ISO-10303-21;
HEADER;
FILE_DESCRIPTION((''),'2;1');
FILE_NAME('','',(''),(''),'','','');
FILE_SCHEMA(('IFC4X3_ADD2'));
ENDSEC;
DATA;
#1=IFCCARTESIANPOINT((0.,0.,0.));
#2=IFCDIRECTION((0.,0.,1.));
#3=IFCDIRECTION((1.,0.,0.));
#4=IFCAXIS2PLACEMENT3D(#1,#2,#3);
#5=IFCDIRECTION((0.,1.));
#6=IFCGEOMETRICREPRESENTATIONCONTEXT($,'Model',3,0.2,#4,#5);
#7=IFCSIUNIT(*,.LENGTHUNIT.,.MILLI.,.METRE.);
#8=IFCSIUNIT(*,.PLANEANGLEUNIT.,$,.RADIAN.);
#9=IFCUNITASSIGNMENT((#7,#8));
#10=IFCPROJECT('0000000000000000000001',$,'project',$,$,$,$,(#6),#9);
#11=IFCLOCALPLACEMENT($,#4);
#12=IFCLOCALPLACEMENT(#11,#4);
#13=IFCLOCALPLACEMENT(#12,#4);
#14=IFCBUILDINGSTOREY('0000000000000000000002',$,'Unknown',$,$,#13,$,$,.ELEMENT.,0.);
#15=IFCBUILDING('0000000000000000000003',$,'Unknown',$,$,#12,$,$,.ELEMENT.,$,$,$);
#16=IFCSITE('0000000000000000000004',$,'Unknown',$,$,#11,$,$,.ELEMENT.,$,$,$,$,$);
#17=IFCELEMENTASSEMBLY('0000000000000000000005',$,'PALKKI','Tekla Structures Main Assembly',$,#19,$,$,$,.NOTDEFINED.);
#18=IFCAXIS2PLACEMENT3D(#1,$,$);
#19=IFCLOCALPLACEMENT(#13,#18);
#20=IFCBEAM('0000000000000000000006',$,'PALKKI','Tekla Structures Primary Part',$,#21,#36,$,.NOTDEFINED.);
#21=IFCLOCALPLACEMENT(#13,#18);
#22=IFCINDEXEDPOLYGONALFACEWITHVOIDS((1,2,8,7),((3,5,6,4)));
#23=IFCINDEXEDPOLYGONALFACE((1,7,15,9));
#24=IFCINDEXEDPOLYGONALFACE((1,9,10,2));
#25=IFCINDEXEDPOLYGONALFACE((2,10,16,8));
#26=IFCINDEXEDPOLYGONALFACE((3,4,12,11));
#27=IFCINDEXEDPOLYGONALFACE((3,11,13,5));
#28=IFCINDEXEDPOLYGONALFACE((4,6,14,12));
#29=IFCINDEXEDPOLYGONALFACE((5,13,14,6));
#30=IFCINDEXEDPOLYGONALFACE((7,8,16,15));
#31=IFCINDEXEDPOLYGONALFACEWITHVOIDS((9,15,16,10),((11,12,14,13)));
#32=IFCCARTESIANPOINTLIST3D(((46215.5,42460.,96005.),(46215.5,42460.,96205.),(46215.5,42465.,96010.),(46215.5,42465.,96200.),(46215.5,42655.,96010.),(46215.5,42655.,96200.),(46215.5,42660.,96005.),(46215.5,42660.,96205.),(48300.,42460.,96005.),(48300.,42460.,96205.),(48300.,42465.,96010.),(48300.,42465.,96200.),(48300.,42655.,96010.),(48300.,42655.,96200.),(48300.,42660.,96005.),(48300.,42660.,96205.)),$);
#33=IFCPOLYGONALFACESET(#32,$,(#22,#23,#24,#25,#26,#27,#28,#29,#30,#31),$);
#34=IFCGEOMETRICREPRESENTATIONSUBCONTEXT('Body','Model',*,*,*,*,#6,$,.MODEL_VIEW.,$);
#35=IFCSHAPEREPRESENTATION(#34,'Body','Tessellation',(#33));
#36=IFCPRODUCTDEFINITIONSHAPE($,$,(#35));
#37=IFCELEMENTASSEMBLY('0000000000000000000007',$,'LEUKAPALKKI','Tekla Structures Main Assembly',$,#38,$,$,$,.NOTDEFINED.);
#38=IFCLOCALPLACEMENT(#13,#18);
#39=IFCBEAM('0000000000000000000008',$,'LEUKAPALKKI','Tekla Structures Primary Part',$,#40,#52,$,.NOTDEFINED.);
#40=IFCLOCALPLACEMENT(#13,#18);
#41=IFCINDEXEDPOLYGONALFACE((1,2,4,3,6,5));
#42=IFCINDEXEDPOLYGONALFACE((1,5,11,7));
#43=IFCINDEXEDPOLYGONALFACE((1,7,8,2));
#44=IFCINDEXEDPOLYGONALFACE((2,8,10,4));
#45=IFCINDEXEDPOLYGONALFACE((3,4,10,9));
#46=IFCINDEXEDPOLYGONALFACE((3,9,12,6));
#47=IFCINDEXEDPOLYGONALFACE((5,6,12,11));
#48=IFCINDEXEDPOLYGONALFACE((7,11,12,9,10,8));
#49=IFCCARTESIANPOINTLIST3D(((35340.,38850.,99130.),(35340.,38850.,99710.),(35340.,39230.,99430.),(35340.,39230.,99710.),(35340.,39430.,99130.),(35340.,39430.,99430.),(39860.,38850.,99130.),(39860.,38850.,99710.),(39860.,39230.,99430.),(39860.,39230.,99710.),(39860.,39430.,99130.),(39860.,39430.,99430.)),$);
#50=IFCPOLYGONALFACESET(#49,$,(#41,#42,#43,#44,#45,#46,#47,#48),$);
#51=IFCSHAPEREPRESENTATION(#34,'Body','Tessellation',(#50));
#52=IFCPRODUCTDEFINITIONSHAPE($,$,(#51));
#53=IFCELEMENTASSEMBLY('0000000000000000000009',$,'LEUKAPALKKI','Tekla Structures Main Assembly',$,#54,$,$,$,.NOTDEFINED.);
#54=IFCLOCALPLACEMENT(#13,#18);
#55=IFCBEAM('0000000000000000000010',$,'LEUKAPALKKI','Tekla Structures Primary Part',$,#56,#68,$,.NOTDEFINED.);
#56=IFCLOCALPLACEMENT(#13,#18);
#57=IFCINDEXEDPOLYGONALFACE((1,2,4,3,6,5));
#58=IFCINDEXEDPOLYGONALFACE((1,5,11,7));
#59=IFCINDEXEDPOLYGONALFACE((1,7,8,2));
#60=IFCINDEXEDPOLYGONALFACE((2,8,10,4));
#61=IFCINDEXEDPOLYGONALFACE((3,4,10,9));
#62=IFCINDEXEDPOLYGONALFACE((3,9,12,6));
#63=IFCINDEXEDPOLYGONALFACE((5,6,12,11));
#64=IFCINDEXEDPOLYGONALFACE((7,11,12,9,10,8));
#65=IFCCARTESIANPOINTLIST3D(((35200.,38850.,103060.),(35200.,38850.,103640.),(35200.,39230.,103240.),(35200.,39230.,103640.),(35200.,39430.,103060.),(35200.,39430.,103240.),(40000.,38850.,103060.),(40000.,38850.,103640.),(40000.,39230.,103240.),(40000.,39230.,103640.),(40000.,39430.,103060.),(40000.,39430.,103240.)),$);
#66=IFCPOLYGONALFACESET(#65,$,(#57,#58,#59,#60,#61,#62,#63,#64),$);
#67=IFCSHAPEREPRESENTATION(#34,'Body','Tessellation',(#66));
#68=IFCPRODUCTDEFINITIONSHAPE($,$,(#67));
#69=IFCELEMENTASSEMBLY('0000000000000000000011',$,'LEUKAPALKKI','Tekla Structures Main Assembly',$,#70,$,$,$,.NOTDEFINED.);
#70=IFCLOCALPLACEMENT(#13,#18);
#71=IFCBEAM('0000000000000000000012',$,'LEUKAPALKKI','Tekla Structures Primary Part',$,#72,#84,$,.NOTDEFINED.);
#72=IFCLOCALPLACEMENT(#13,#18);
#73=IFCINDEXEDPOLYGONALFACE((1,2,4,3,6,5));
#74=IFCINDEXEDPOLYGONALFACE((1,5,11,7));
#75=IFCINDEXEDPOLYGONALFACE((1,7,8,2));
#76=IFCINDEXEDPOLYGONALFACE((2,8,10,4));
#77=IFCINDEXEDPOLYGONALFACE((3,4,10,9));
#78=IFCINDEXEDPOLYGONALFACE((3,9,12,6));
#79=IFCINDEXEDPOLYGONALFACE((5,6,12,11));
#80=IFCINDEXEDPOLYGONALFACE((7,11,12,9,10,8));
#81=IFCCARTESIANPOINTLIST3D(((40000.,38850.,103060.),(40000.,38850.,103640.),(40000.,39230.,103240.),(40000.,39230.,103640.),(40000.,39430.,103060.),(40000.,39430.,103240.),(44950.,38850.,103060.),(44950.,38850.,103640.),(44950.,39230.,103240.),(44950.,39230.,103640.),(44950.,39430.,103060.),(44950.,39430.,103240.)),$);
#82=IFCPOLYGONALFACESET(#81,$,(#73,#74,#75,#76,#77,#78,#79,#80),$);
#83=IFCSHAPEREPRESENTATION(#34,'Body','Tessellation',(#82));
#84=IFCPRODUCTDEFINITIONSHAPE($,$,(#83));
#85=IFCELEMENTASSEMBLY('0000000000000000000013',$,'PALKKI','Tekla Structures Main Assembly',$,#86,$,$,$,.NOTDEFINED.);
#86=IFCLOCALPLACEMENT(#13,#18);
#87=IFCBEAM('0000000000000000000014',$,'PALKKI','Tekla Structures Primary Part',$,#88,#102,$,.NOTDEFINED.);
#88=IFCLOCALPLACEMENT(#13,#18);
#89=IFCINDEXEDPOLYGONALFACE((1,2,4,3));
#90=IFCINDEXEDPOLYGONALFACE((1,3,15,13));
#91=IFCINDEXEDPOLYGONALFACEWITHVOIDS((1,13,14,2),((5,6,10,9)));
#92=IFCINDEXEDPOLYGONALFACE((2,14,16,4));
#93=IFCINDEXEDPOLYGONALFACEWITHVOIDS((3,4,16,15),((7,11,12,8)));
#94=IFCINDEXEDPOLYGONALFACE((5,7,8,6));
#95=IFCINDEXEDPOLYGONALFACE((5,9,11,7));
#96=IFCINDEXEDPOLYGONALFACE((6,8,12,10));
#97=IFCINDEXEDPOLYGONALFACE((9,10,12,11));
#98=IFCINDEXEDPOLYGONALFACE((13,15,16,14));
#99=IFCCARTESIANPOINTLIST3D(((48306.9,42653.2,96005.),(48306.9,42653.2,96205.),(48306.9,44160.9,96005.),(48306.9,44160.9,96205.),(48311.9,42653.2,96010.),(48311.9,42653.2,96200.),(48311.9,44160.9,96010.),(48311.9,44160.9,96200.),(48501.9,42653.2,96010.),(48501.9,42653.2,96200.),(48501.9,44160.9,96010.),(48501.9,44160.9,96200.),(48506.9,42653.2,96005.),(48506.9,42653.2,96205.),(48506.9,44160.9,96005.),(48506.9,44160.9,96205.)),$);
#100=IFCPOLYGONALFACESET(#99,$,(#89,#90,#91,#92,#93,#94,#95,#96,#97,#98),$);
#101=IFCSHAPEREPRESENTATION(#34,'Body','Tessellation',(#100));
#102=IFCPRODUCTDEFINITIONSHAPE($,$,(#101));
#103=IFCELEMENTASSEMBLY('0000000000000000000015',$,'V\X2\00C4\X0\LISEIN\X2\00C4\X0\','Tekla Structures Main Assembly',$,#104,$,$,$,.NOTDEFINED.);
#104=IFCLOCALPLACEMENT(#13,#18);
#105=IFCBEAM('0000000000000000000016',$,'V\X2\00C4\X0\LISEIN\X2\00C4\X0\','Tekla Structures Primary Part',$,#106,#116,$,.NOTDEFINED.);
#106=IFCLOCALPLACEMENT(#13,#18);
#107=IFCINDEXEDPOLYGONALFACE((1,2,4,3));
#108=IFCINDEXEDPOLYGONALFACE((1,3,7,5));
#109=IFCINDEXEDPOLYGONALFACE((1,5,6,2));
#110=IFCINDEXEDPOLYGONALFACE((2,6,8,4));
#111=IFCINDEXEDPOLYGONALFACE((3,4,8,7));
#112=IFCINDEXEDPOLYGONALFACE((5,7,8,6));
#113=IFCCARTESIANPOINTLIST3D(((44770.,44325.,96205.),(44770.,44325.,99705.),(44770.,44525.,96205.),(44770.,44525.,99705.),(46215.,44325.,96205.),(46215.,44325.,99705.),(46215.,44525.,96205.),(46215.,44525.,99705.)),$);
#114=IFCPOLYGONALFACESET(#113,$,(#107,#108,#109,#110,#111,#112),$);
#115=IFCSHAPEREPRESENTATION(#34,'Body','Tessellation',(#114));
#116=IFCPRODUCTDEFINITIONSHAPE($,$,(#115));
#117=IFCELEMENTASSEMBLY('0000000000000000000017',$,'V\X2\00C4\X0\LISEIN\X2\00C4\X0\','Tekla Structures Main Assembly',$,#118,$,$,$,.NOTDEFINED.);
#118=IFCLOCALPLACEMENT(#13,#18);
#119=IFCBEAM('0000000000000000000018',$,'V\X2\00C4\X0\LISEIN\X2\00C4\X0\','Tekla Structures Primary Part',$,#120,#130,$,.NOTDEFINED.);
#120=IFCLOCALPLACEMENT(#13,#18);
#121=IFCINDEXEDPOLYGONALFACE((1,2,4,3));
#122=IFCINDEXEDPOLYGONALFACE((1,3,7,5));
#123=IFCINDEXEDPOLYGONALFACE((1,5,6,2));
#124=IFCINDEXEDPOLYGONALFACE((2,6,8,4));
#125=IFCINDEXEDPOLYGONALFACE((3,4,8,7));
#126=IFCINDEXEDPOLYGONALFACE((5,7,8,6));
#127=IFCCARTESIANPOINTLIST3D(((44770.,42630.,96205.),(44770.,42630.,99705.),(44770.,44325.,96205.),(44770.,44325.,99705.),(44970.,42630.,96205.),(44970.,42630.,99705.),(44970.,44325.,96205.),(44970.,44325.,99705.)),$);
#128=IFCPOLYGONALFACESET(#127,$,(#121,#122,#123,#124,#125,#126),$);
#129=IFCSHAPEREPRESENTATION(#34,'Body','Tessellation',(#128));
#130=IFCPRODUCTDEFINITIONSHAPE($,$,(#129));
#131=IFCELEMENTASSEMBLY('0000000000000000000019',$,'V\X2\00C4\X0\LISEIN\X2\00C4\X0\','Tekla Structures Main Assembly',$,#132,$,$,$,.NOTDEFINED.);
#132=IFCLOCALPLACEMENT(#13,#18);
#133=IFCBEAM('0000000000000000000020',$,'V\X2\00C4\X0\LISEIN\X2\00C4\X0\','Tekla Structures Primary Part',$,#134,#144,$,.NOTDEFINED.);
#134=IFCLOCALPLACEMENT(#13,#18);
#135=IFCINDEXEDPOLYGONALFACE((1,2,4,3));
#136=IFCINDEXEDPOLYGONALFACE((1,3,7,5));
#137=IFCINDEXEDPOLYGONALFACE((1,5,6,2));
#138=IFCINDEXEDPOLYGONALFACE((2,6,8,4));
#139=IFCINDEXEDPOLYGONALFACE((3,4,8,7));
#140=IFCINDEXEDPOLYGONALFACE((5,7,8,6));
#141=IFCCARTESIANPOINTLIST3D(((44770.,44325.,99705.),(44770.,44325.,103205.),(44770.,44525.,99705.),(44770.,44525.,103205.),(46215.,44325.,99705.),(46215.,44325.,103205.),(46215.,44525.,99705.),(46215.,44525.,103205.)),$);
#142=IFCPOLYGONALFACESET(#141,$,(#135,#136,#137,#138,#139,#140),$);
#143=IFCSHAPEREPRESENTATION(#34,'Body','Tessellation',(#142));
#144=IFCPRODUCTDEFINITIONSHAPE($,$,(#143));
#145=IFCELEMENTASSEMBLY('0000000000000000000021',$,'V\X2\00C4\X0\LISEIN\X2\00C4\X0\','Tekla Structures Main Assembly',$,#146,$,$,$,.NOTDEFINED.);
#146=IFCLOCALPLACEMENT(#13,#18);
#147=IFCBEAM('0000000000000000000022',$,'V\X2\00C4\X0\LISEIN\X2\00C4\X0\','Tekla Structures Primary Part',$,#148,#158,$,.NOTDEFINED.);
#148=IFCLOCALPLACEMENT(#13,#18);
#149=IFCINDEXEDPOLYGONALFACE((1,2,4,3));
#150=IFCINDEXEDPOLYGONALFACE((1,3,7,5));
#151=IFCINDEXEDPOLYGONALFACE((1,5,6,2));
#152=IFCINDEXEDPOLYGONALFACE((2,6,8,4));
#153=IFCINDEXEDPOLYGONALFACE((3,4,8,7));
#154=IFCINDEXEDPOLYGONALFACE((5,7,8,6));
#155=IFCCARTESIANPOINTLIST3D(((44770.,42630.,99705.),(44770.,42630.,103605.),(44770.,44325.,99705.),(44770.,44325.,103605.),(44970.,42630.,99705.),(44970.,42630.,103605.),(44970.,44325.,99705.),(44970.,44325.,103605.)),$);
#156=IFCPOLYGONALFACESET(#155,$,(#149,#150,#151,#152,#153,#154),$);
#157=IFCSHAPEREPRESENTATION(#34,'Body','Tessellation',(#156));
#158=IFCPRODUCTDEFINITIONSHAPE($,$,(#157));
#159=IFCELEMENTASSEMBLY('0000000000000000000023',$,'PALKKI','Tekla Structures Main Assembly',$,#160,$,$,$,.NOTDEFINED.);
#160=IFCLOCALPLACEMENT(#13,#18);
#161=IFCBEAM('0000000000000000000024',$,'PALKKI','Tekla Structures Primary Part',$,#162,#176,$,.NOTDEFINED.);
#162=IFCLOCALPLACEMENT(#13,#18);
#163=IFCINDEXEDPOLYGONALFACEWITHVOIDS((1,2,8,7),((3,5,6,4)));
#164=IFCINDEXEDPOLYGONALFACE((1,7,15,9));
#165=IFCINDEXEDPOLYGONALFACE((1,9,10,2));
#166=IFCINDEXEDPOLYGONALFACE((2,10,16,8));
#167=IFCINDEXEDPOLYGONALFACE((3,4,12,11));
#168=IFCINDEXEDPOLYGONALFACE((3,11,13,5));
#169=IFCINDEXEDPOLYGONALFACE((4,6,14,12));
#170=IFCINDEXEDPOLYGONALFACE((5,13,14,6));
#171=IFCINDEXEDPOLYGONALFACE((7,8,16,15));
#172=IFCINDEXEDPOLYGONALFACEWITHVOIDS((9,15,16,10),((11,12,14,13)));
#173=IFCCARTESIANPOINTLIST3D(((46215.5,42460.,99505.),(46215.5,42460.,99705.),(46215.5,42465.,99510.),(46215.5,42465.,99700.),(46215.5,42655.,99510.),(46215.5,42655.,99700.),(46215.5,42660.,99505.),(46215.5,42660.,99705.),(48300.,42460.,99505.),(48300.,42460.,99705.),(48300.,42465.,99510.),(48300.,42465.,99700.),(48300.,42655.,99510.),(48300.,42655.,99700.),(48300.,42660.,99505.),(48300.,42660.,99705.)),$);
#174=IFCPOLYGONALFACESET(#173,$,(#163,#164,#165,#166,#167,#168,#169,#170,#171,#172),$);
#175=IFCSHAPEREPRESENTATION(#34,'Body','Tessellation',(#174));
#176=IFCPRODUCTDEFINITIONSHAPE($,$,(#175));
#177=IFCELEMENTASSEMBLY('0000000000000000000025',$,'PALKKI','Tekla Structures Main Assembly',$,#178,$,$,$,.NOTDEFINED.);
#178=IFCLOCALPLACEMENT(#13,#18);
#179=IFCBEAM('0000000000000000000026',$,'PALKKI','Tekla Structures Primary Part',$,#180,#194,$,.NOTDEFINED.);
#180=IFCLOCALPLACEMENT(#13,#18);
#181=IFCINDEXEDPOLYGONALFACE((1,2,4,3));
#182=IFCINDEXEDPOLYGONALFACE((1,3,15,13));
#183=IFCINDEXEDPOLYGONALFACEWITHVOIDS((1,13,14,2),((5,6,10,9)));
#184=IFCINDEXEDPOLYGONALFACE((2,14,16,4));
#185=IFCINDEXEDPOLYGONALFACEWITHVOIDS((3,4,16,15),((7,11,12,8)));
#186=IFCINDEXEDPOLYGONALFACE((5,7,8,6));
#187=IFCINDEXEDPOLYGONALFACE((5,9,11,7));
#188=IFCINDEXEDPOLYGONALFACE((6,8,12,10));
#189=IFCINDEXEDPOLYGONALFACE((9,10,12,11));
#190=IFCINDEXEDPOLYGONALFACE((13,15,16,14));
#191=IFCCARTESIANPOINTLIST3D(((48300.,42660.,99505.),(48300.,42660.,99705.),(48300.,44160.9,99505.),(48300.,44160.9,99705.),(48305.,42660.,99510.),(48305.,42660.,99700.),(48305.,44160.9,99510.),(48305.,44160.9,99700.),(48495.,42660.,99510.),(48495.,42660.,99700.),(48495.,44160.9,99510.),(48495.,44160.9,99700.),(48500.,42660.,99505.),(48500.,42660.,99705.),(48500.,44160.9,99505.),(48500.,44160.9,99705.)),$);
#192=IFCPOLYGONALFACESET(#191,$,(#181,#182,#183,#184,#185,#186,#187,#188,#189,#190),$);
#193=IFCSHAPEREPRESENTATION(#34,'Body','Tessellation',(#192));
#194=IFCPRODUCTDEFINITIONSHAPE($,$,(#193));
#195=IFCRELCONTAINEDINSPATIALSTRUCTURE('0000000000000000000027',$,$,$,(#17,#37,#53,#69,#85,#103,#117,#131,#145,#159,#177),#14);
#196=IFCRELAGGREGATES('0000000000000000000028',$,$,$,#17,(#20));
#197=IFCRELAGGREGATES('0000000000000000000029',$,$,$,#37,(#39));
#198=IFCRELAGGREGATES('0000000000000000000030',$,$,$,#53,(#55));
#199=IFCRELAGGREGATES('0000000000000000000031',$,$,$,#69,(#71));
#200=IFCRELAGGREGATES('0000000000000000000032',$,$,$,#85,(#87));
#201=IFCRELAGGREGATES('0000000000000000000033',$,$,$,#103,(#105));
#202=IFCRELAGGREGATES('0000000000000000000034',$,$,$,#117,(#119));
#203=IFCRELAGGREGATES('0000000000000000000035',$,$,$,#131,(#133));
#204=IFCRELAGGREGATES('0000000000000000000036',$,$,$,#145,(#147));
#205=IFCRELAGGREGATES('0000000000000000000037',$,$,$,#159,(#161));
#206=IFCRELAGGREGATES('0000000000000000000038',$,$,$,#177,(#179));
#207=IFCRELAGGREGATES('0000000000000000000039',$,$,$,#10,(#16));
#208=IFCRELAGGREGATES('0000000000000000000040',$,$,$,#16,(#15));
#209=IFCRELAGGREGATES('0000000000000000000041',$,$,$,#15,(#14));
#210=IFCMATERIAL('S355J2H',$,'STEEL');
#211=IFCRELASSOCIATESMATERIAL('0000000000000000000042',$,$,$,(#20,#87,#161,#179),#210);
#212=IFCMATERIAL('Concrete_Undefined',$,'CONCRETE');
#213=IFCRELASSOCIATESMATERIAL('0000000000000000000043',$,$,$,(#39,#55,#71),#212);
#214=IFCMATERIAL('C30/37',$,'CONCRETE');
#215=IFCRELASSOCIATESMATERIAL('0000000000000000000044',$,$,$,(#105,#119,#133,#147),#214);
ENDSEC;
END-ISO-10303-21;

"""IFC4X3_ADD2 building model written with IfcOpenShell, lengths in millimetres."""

from ifc_helpers import new_model, si_unit, direction, frame, origin_with_axes, place, context, subcontext, project, spatial, line, indexed_curve, outline, extrude, material, element, aggregate, save


model = new_model("IFC4X3_ADD2")

# Units and contexts
model_context = context("Model", 3, precision=0.2, world=origin_with_axes(), true_north=direction((0.0, 1.0)))
body_context = subcontext(model_context, "Body", "Model", "MODEL_VIEW")
ifc_project = project(units=[si_unit("LENGTHUNIT", "METRE", prefix="MILLI"), si_unit("PLANEANGLEUNIT", "RADIAN")], contexts=[model_context])

# Site, building, storey
site_placement = place(None, origin_with_axes())
site = spatial("IfcSite", under=ifc_project, at=site_placement, Name="Unknown", CompositionType="ELEMENT")
building_placement = place(site_placement, origin_with_axes())
building = spatial("IfcBuilding", under=site, at=building_placement, Name="Unknown", CompositionType="ELEMENT")
storey_placement = place(building_placement, origin_with_axes())
storey = spatial("IfcBuildingStorey", under=building, at=storey_placement, Name="Unknown", CompositionType="ELEMENT", Elevation=0.0)

# Element assemblies, beams
assembly_1_placement = place(storey_placement, frame((46215.5, 42560.0, 96105.0), z_axis=(0.0, -1.0, 0.0), x_axis=(1.0, 0.0, 0.0)))
assembly_1 = element("IfcElementAssembly", 1, at=assembly_1_placement, inside=storey, Name="PALKKI", Description="Tekla Structures Main Assembly", PredefinedType="NOTDEFINED")
ifc_material_1 = material(Name="S355J2H", Category="STEEL")
beam_1_placement = place(assembly_1_placement, origin_with_axes())
beam_1 = element("IfcBeam", 2, at=beam_1_placement, material=ifc_material_1, Name="PALKKI", Description="Tekla Structures Primary Part", PredefinedType="NOTDEFINED", context=body_context, shape_type="SolidModel", body=[
    extrude(outline(indexed_curve([(-100.0, -100.0), (100.0, -100.0), (100.0, 100.0), (-100.0, 100.0)], segments=[line(1, 2, 3, 4, 1)]), holes=[indexed_curve([(-95.0, -95.0), (-95.0, 95.0), (95.0, 95.0), (95.0, -95.0)], segments=[line(1, 2, 3, 4, 1)])]), frame((0.0, 0.0, 0.0), z_axis=(-1.0, 0.0, 0.0), x_axis=(0.0, 0.0, 1.0)), (0.0, 0.0, -1.0), 2084.5),
])
aggregate(assembly_1, [beam_1])
assembly_2_placement = place(storey_placement, frame((39860.0, 39040.0, 99420.0), z_axis=(0.0, 1.0, 0.0), x_axis=(-1.0, 0.0, 0.0)))
assembly_2 = element("IfcElementAssembly", 3, at=assembly_2_placement, inside=storey, Name="LEUKAPALKKI", Description="Tekla Structures Main Assembly", PredefinedType="NOTDEFINED")
ifc_material_2 = material(Name="Concrete_Undefined", Category="CONCRETE")
beam_2_placement = place(assembly_2_placement, origin_with_axes())
beam_2 = element("IfcBeam", 4, at=beam_2_placement, material=ifc_material_2, Name="LEUKAPALKKI", Description="Tekla Structures Primary Part", PredefinedType="NOTDEFINED", context=body_context, shape_type="SolidModel", body=[
    extrude(outline(indexed_curve([(-190.0, -290.0), (390.0, -290.0), (390.0, 10.0), (190.0, 10.0), (190.0, 290.0), (-190.0, 290.0)], segments=[line(1, 2, 3, 4, 5, 6, 1)])), frame((0.0, 0.0, 0.0), z_axis=(-1.0, 0.0, 0.0), x_axis=(0.0, 0.0, 1.0)), (0.0, 0.0, -1.0), 4520.0),
])
aggregate(assembly_2, [beam_2])

# Element assemblies, beams
assembly_3_placement = place(storey_placement, frame((40000.0, 39040.0, 103350.0), z_axis=(0.0, 1.0, 0.0), x_axis=(-1.0, 0.0, 0.0)))
assembly_3 = element("IfcElementAssembly", 5, at=assembly_3_placement, inside=storey, Name="LEUKAPALKKI", Description="Tekla Structures Main Assembly", PredefinedType="NOTDEFINED")
beam_3_placement = place(assembly_3_placement, origin_with_axes())
beam_3 = element("IfcBeam", 6, at=beam_3_placement, material=ifc_material_2, Name="LEUKAPALKKI", Description="Tekla Structures Primary Part", PredefinedType="NOTDEFINED", context=body_context, shape_type="SolidModel", body=[
    extrude(outline(indexed_curve([(-190.0, -290.0), (390.0, -290.0), (390.0, -110.0), (190.0, -110.0), (190.0, 290.0), (-190.0, 290.0)], segments=[line(1, 2, 3, 4, 5, 6, 1)])), frame((0.0, 0.0, 0.0), z_axis=(-1.0, 0.0, 0.0), x_axis=(0.0, 0.0, 1.0)), (0.0, 0.0, -1.0), 4800.0),
])
aggregate(assembly_3, [beam_3])
assembly_4_placement = place(storey_placement, frame((44950.0, 39040.0, 103350.0), z_axis=(0.0, 1.0, 0.0), x_axis=(-1.0, 0.0, 0.0)))
assembly_4 = element("IfcElementAssembly", 7, at=assembly_4_placement, inside=storey, Name="LEUKAPALKKI", Description="Tekla Structures Main Assembly", PredefinedType="NOTDEFINED")
beam_4_placement = place(assembly_4_placement, origin_with_axes())
beam_4 = element("IfcBeam", 8, at=beam_4_placement, material=ifc_material_2, Name="LEUKAPALKKI", Description="Tekla Structures Primary Part", PredefinedType="NOTDEFINED", context=body_context, shape_type="SolidModel", body=[
    extrude(outline(indexed_curve([(-190.0, -290.0), (390.0, -290.0), (390.0, -110.0), (190.0, -110.0), (190.0, 290.0), (-190.0, 290.0)], segments=[line(1, 2, 3, 4, 5, 6, 1)])), frame((0.0, 0.0, 0.0), z_axis=(-1.0, 0.0, 0.0), x_axis=(0.0, 0.0, 1.0)), (0.0, 0.0, -1.0), 4950.0),
])
aggregate(assembly_4, [beam_4])
assembly_5_placement = place(storey_placement, frame((48406.9, 44160.9, 96105.0), z_axis=(-1.0, 0.0, 0.0), x_axis=(0.0, -1.0, 0.0)))
assembly_5 = element("IfcElementAssembly", 9, at=assembly_5_placement, inside=storey, Name="PALKKI", Description="Tekla Structures Main Assembly", PredefinedType="NOTDEFINED")
beam_5_placement = place(assembly_5_placement, origin_with_axes())
beam_5 = element("IfcBeam", 10, at=beam_5_placement, material=ifc_material_1, Name="PALKKI", Description="Tekla Structures Primary Part", PredefinedType="NOTDEFINED", context=body_context, shape_type="SolidModel", body=[
    extrude(outline(indexed_curve([(-100.0, -100.0), (100.0, -100.0), (100.0, 100.0), (-100.0, 100.0)], segments=[line(1, 2, 3, 4, 1)]), holes=[indexed_curve([(-95.0, -95.0), (-95.0, 95.0), (95.0, 95.0), (95.0, -95.0)], segments=[line(1, 2, 3, 4, 1)])]), frame((0.0, 0.0, 0.0), z_axis=(-1.0, 0.0, 0.0), x_axis=(0.0, 0.0, 1.0)), (0.0, 0.0, -1.0), 1507.8),
])
aggregate(assembly_5, [beam_5])

# Element assemblies, beams
assembly_6_placement = place(storey_placement, frame((46215.0, 44425.0, 97955.0), z_axis=(0.0, 1.0, 0.0), x_axis=(-1.0, 0.0, 0.0)))
assembly_6 = element("IfcElementAssembly", 11, at=assembly_6_placement, inside=storey, Name="VÄLISEINÄ", Description="Tekla Structures Main Assembly", PredefinedType="NOTDEFINED")
ifc_material_3 = material(Name="C30/37", Category="CONCRETE")
beam_6_placement = place(assembly_6_placement, origin_with_axes())
beam_6 = element("IfcBeam", 12, at=beam_6_placement, material=ifc_material_3, Name="VÄLISEINÄ", Description="Tekla Structures Primary Part", PredefinedType="NOTDEFINED", context=body_context, shape_type="SolidModel", body=[
    extrude(outline(indexed_curve([(-100.0, -1750.0), (100.0, -1750.0), (100.0, 1750.0), (-100.0, 1750.0)], segments=[line(1, 2, 3, 4, 1)])), frame((0.0, 0.0, 0.0), z_axis=(-1.0, 0.0, 0.0), x_axis=(0.0, 0.0, 1.0)), (0.0, 0.0, -1.0), 1445.0),
])
aggregate(assembly_6, [beam_6])
assembly_7_placement = place(storey_placement, frame((44870.0, 44325.0, 97955.0), z_axis=(-1.0, 0.0, 0.0), x_axis=(0.0, -1.0, 0.0)))
assembly_7 = element("IfcElementAssembly", 13, at=assembly_7_placement, inside=storey, Name="VÄLISEINÄ", Description="Tekla Structures Main Assembly", PredefinedType="NOTDEFINED")
beam_7_placement = place(assembly_7_placement, origin_with_axes())
beam_7 = element("IfcBeam", 14, at=beam_7_placement, material=ifc_material_3, Name="VÄLISEINÄ", Description="Tekla Structures Primary Part", PredefinedType="NOTDEFINED", context=body_context, shape_type="SolidModel", body=[
    extrude(outline(indexed_curve([(-100.0, -1750.0), (100.0, -1750.0), (100.0, 1750.0), (-100.0, 1750.0)], segments=[line(1, 2, 3, 4, 1)])), frame((0.0, 0.0, 0.0), z_axis=(-1.0, 0.0, 0.0), x_axis=(0.0, 0.0, 1.0)), (0.0, 0.0, -1.0), 1695.0),
])
aggregate(assembly_7, [beam_7])
assembly_8_placement = place(storey_placement, frame((46215.0, 44425.0, 101455.0), z_axis=(0.0, 1.0, 0.0), x_axis=(-1.0, 0.0, 0.0)))
assembly_8 = element("IfcElementAssembly", 15, at=assembly_8_placement, inside=storey, Name="VÄLISEINÄ", Description="Tekla Structures Main Assembly", PredefinedType="NOTDEFINED")
beam_8_placement = place(assembly_8_placement, origin_with_axes())
beam_8 = element("IfcBeam", 16, at=beam_8_placement, material=ifc_material_3, Name="VÄLISEINÄ", Description="Tekla Structures Primary Part", PredefinedType="NOTDEFINED", context=body_context, shape_type="SolidModel", body=[
    extrude(outline(indexed_curve([(-100.0, -1750.0), (100.0, -1750.0), (100.0, 1750.0), (-100.0, 1750.0)], segments=[line(1, 2, 3, 4, 1)])), frame((0.0, 0.0, 0.0), z_axis=(-1.0, 0.0, 0.0), x_axis=(0.0, 0.0, 1.0)), (0.0, 0.0, -1.0), 1445.0),
])
aggregate(assembly_8, [beam_8])
assembly_9_placement = place(storey_placement, frame((44870.0, 44325.0, 101655.0), z_axis=(-1.0, 0.0, 0.0), x_axis=(0.0, -1.0, 0.0)))
assembly_9 = element("IfcElementAssembly", 17, at=assembly_9_placement, inside=storey, Name="VÄLISEINÄ", Description="Tekla Structures Main Assembly", PredefinedType="NOTDEFINED")
beam_9_placement = place(assembly_9_placement, origin_with_axes())
beam_9 = element("IfcBeam", 18, at=beam_9_placement, material=ifc_material_3, Name="VÄLISEINÄ", Description="Tekla Structures Primary Part", PredefinedType="NOTDEFINED", context=body_context, shape_type="SolidModel", body=[
    extrude(outline(indexed_curve([(-100.0, -1950.0), (100.0, -1950.0), (100.0, 1950.0), (-100.0, 1950.0)], segments=[line(1, 2, 3, 4, 1)])), frame((0.0, 0.0, 0.0), z_axis=(-1.0, 0.0, 0.0), x_axis=(0.0, 0.0, 1.0)), (0.0, 0.0, -1.0), 1695.0),
])
aggregate(assembly_9, [beam_9])
assembly_10_placement = place(storey_placement, frame((46215.5, 42560.0, 99605.0), z_axis=(0.0, -1.0, 0.0), x_axis=(1.0, 0.0, 0.0)))
assembly_10 = element("IfcElementAssembly", 19, at=assembly_10_placement, inside=storey, Name="PALKKI", Description="Tekla Structures Main Assembly", PredefinedType="NOTDEFINED")
beam_10_placement = place(assembly_10_placement, origin_with_axes())
beam_10 = element("IfcBeam", 20, at=beam_10_placement, material=ifc_material_1, Name="PALKKI", Description="Tekla Structures Primary Part", PredefinedType="NOTDEFINED", context=body_context, shape_type="SolidModel", body=[
    extrude(outline(indexed_curve([(-100.0, -100.0), (100.0, -100.0), (100.0, 100.0), (-100.0, 100.0)], segments=[line(1, 2, 3, 4, 1)]), holes=[indexed_curve([(-95.0, -95.0), (-95.0, 95.0), (95.0, 95.0), (95.0, -95.0)], segments=[line(1, 2, 3, 4, 1)])]), frame((0.0, 0.0, 0.0), z_axis=(-1.0, 0.0, 0.0), x_axis=(0.0, 0.0, 1.0)), (0.0, 0.0, -1.0), 2084.5),
])
aggregate(assembly_10, [beam_10])
assembly_11_placement = place(storey_placement, frame((48400.0, 44160.9, 99605.0), z_axis=(-1.0, 0.0, 0.0), x_axis=(0.0, -1.0, 0.0)))
assembly_11 = element("IfcElementAssembly", 21, at=assembly_11_placement, inside=storey, Name="PALKKI", Description="Tekla Structures Main Assembly", PredefinedType="NOTDEFINED")
beam_11_placement = place(assembly_11_placement, origin_with_axes())
beam_11 = element("IfcBeam", 22, at=beam_11_placement, material=ifc_material_1, Name="PALKKI", Description="Tekla Structures Primary Part", PredefinedType="NOTDEFINED", context=body_context, shape_type="SolidModel", body=[
    extrude(outline(indexed_curve([(-100.0, -100.0), (100.0, -100.0), (100.0, 100.0), (-100.0, 100.0)], segments=[line(1, 2, 3, 4, 1)]), holes=[indexed_curve([(-95.0, -95.0), (-95.0, 95.0), (95.0, 95.0), (95.0, -95.0)], segments=[line(1, 2, 3, 4, 1)])]), frame((0.0, 0.0, 0.0), z_axis=(-1.0, 0.0, 0.0), x_axis=(0.0, 0.0, 1.0)), (0.0, 0.0, -1.0), 1500.9),
])
aggregate(assembly_11, [beam_11])

save(model, "model.ifc")
